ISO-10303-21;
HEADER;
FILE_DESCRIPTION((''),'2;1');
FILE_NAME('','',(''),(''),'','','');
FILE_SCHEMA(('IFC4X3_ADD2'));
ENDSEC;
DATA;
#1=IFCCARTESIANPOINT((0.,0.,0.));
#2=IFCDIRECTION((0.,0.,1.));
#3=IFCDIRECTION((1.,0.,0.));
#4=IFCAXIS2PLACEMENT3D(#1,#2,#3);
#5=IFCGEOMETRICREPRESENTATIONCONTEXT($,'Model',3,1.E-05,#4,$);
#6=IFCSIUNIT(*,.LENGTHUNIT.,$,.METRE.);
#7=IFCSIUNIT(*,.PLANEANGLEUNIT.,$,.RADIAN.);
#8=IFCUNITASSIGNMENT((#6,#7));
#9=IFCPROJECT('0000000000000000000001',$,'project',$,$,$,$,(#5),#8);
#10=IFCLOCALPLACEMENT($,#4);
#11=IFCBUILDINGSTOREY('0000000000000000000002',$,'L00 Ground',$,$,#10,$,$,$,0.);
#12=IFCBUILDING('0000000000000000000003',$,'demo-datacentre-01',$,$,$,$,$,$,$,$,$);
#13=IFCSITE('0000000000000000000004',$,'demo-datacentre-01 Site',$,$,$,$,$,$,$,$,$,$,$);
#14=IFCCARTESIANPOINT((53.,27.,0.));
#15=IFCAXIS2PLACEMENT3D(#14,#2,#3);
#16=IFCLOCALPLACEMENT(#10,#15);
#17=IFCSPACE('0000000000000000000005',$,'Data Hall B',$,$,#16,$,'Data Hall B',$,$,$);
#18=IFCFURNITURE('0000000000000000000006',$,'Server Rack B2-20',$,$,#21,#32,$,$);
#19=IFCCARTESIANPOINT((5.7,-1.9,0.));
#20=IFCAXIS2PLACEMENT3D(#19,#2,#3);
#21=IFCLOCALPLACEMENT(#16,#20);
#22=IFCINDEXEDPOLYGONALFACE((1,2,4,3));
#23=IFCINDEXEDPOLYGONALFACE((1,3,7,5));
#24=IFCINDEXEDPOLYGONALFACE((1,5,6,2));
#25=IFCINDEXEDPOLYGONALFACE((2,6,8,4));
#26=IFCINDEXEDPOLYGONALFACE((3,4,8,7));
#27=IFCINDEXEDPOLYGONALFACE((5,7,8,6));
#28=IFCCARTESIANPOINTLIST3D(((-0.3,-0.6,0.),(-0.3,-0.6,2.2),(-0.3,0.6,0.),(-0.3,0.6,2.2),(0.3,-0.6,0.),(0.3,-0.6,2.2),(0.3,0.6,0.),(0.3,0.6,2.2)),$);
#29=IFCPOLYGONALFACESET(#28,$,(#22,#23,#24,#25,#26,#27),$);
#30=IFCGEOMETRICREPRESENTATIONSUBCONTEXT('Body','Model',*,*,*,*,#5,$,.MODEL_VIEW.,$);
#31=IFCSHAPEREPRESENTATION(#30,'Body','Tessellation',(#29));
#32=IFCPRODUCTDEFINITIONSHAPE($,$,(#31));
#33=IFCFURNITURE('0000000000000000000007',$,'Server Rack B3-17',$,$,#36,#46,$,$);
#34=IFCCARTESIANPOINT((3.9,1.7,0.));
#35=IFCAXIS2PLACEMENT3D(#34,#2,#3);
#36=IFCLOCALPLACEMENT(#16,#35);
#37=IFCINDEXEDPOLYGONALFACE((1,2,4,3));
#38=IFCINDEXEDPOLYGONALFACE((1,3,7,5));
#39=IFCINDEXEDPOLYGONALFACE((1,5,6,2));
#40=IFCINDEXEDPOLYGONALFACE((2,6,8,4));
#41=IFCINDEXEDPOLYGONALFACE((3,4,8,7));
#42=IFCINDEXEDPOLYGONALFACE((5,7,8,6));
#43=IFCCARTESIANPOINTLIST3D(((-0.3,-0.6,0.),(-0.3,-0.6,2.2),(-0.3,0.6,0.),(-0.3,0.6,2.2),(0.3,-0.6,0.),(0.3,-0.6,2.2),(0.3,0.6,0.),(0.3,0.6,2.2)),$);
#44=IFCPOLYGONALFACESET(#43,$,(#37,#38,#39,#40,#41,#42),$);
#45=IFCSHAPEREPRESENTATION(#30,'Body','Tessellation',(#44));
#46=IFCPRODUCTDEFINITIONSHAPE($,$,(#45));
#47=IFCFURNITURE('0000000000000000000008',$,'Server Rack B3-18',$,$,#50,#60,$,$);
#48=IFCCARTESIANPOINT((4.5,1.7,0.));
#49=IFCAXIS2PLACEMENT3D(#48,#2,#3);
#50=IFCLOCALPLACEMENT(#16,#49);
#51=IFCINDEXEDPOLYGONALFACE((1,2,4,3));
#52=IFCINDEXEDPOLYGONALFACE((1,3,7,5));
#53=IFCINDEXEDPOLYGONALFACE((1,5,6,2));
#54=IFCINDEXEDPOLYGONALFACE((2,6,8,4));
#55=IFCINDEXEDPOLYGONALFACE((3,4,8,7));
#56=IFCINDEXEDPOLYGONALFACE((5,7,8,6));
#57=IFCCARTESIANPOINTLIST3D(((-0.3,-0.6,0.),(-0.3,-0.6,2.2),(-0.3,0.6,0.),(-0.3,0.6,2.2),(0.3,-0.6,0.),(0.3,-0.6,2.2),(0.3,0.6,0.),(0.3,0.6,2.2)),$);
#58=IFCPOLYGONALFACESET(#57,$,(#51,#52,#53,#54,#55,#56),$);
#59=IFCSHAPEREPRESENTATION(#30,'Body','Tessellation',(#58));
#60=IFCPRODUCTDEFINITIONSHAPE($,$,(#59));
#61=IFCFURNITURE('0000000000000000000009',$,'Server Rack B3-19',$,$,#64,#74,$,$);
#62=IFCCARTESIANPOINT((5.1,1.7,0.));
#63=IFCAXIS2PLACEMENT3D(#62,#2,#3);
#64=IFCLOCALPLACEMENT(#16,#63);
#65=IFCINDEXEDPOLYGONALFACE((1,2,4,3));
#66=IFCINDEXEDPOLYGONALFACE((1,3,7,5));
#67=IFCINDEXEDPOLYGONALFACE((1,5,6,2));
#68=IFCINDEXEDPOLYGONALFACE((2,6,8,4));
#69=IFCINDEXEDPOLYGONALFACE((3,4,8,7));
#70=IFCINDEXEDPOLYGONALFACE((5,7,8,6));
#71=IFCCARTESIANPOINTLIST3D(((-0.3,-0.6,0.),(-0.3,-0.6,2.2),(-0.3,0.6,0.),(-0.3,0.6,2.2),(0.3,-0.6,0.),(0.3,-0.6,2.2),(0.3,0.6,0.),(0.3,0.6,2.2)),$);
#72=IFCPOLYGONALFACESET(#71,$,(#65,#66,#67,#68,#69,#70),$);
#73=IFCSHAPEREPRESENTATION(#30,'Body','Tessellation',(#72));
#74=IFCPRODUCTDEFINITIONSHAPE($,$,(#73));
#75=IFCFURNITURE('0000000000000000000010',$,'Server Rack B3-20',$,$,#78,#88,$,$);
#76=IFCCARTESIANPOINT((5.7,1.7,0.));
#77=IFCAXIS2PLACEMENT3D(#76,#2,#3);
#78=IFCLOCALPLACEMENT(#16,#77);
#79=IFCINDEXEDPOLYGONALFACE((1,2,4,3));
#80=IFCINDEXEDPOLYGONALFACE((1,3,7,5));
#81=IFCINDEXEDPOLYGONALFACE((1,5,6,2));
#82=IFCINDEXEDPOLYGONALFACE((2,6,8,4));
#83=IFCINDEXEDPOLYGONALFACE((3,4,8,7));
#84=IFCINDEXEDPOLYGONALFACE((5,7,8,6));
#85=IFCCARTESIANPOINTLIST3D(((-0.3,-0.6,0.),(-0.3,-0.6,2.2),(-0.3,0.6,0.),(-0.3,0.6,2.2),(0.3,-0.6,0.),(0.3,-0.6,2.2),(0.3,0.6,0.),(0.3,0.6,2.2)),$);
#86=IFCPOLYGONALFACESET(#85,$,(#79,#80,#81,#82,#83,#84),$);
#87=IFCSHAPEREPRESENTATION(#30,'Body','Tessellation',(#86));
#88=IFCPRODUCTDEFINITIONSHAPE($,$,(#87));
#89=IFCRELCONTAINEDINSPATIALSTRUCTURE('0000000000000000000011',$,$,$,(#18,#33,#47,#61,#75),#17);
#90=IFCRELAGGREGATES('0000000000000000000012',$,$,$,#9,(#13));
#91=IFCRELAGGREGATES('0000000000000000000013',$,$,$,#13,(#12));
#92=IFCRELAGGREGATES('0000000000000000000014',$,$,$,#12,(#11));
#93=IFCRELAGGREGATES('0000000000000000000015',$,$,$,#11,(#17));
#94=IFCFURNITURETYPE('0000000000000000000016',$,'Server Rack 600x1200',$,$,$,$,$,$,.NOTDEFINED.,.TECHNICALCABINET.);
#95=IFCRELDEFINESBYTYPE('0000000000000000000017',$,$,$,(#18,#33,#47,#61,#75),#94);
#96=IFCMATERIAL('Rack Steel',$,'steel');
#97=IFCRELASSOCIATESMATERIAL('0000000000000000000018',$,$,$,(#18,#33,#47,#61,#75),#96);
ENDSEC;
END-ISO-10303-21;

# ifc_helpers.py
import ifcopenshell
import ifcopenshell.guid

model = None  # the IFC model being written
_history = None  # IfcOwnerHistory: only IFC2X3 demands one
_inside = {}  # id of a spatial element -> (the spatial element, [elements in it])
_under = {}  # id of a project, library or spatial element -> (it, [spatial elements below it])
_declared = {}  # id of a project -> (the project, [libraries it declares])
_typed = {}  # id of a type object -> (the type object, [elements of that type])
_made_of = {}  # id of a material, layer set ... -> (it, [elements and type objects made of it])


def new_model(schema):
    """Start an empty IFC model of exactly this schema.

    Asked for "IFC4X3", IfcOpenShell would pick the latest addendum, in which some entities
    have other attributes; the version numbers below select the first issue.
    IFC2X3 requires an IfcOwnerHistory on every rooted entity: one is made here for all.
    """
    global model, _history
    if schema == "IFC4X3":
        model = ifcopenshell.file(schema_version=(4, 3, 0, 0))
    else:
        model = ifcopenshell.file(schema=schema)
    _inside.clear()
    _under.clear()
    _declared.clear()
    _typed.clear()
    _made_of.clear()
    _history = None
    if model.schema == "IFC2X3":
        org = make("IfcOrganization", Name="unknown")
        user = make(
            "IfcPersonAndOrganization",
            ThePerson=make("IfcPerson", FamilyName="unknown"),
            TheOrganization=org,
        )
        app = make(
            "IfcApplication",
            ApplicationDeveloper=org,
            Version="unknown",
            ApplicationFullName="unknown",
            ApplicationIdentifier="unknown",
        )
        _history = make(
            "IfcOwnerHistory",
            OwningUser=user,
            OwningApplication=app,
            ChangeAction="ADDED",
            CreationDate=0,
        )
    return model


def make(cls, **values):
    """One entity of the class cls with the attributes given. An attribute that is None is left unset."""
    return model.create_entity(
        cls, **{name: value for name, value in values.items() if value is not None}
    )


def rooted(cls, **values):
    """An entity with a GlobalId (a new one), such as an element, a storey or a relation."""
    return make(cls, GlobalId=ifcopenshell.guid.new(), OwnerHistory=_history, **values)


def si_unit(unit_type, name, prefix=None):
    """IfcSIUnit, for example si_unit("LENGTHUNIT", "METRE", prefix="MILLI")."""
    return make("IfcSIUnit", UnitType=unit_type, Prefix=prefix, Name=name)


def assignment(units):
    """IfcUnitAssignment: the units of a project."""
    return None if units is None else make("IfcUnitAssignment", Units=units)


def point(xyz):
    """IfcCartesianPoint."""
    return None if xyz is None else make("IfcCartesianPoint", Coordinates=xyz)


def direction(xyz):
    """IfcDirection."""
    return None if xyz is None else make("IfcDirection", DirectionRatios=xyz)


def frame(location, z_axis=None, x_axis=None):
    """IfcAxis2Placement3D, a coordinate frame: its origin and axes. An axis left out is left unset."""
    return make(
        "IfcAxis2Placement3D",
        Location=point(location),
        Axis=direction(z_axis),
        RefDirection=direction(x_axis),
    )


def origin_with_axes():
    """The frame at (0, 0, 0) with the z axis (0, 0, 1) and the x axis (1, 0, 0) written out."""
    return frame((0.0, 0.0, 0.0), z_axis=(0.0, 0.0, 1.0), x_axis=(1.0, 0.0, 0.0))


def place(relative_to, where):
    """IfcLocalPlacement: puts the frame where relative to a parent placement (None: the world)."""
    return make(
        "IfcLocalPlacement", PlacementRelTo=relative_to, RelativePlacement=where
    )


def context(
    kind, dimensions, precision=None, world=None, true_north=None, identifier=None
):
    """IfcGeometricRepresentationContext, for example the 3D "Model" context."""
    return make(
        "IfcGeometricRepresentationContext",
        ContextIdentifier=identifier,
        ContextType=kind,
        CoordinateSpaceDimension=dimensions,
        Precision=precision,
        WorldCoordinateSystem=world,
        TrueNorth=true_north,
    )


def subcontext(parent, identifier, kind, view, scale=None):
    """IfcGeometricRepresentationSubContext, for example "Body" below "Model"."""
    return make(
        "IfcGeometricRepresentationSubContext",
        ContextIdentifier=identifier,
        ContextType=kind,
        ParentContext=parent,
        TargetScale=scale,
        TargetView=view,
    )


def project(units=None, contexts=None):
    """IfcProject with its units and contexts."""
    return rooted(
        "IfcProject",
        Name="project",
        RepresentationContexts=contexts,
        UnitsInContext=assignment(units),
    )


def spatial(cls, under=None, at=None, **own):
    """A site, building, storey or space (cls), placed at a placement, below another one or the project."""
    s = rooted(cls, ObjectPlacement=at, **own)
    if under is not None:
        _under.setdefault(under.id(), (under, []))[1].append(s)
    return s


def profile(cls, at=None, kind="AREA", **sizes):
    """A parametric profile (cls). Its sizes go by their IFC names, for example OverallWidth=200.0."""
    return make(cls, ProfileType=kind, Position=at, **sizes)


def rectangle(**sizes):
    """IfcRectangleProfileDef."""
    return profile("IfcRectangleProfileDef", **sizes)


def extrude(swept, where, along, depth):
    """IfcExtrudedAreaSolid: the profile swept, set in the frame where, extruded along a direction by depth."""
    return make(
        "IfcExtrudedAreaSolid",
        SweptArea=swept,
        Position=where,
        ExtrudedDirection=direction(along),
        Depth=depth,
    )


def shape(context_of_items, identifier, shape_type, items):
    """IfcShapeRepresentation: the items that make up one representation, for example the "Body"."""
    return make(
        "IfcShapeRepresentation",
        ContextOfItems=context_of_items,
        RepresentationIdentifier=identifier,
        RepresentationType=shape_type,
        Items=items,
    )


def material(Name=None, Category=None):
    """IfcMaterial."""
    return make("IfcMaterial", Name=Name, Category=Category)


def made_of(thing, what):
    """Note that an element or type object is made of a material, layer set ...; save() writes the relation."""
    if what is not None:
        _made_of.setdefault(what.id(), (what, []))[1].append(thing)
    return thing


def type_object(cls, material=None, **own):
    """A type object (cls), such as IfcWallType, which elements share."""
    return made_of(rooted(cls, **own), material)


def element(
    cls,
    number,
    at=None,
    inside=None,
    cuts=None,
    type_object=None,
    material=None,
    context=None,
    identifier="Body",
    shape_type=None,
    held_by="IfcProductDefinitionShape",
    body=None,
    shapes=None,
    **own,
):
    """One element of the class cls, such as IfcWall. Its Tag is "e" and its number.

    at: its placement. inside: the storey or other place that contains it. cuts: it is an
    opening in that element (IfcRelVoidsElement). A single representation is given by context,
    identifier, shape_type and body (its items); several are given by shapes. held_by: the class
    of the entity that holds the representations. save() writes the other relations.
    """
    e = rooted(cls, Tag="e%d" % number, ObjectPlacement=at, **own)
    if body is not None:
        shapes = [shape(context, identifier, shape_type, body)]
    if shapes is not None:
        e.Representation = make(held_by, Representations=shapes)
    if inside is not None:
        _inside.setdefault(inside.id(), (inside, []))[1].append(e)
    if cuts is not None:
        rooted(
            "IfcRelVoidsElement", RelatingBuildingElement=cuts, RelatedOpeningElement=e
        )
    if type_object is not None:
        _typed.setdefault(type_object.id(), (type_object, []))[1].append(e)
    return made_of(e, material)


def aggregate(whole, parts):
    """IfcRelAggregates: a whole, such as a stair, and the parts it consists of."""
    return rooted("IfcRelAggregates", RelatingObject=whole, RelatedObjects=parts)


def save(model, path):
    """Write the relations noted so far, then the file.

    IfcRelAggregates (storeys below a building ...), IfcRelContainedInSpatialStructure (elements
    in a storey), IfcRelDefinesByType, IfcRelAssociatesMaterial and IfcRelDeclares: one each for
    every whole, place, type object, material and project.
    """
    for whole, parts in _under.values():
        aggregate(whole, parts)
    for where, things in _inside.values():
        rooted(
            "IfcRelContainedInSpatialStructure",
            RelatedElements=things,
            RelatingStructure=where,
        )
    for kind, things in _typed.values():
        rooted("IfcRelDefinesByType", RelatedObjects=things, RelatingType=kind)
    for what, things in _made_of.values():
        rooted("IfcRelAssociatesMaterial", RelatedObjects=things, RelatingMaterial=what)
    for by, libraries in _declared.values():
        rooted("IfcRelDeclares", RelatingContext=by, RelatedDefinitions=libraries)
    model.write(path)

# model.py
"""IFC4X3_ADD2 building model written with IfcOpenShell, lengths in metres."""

from ifc_helpers import new_model, si_unit, frame, origin_with_axes, place, context, subcontext, project, spatial, rectangle, extrude, material, type_object, element, save


model = new_model("IFC4X3_ADD2")

# Units and contexts
model_context = context("Model", 3, precision=1e-05, world=origin_with_axes())
body_context = subcontext(model_context, "Body", "Model", "MODEL_VIEW")
ifc_project = project(units=[si_unit("LENGTHUNIT", "METRE"), si_unit("PLANEANGLEUNIT", "RADIAN")], contexts=[model_context])

# Site, building, storey
site = spatial("IfcSite", under=ifc_project, Name="demo-datacentre-01 Site")
building = spatial("IfcBuilding", under=site, Name="demo-datacentre-01")
storey_placement = place(None, origin_with_axes())
storey = spatial("IfcBuildingStorey", under=building, at=storey_placement, Name="L00 Ground", Elevation=0.0)

# Shared definitions
space_placement = place(storey_placement, frame((53.0, 27.0, 0.0), z_axis=(0.0, 0.0, 1.0), x_axis=(1.0, 0.0, 0.0)))
space = spatial("IfcSpace", under=storey, at=space_placement, Name="Data Hall B", LongName="Data Hall B")

# Furniture
ifc_material_1 = material(Name="Rack Steel", Category="steel")
furniture_type = type_object("IfcFurnitureType", Name="Server Rack 600x1200", AssemblyPlace="NOTDEFINED", PredefinedType="TECHNICALCABINET")
for number, where, z_axis, x_axis, name in (
    (1, (5.7, -1.9, 0.0), (0.0, 0.0, 1.0), (1.0, 0.0, 0.0), "Server Rack B2-20"),
    (2, (3.9, 1.7, 0.0), (0.0, 0.0, 1.0), (1.0, 0.0, 0.0), "Server Rack B3-17"),
    (3, (4.5, 1.7, 0.0), (0.0, 0.0, 1.0), (1.0, 0.0, 0.0), "Server Rack B3-18"),
    (4, (5.1, 1.7, 0.0), (0.0, 0.0, 1.0), (1.0, 0.0, 0.0), "Server Rack B3-19"),
    (5, (5.7, 1.7, 0.0), (0.0, 0.0, 1.0), (1.0, 0.0, 0.0), "Server Rack B3-20"),
):
    element("IfcFurniture", number, at=place(space_placement, frame(where, z_axis=z_axis, x_axis=x_axis)), inside=space, type_object=furniture_type, material=ifc_material_1, Name=name, context=body_context, shape_type="SweptSolid", body=[
        extrude(rectangle(XDim=0.6, YDim=1.2), origin_with_axes(), (0.0, 0.0, 1.0), 2.2),
    ])

save(model, "model.ifc")
